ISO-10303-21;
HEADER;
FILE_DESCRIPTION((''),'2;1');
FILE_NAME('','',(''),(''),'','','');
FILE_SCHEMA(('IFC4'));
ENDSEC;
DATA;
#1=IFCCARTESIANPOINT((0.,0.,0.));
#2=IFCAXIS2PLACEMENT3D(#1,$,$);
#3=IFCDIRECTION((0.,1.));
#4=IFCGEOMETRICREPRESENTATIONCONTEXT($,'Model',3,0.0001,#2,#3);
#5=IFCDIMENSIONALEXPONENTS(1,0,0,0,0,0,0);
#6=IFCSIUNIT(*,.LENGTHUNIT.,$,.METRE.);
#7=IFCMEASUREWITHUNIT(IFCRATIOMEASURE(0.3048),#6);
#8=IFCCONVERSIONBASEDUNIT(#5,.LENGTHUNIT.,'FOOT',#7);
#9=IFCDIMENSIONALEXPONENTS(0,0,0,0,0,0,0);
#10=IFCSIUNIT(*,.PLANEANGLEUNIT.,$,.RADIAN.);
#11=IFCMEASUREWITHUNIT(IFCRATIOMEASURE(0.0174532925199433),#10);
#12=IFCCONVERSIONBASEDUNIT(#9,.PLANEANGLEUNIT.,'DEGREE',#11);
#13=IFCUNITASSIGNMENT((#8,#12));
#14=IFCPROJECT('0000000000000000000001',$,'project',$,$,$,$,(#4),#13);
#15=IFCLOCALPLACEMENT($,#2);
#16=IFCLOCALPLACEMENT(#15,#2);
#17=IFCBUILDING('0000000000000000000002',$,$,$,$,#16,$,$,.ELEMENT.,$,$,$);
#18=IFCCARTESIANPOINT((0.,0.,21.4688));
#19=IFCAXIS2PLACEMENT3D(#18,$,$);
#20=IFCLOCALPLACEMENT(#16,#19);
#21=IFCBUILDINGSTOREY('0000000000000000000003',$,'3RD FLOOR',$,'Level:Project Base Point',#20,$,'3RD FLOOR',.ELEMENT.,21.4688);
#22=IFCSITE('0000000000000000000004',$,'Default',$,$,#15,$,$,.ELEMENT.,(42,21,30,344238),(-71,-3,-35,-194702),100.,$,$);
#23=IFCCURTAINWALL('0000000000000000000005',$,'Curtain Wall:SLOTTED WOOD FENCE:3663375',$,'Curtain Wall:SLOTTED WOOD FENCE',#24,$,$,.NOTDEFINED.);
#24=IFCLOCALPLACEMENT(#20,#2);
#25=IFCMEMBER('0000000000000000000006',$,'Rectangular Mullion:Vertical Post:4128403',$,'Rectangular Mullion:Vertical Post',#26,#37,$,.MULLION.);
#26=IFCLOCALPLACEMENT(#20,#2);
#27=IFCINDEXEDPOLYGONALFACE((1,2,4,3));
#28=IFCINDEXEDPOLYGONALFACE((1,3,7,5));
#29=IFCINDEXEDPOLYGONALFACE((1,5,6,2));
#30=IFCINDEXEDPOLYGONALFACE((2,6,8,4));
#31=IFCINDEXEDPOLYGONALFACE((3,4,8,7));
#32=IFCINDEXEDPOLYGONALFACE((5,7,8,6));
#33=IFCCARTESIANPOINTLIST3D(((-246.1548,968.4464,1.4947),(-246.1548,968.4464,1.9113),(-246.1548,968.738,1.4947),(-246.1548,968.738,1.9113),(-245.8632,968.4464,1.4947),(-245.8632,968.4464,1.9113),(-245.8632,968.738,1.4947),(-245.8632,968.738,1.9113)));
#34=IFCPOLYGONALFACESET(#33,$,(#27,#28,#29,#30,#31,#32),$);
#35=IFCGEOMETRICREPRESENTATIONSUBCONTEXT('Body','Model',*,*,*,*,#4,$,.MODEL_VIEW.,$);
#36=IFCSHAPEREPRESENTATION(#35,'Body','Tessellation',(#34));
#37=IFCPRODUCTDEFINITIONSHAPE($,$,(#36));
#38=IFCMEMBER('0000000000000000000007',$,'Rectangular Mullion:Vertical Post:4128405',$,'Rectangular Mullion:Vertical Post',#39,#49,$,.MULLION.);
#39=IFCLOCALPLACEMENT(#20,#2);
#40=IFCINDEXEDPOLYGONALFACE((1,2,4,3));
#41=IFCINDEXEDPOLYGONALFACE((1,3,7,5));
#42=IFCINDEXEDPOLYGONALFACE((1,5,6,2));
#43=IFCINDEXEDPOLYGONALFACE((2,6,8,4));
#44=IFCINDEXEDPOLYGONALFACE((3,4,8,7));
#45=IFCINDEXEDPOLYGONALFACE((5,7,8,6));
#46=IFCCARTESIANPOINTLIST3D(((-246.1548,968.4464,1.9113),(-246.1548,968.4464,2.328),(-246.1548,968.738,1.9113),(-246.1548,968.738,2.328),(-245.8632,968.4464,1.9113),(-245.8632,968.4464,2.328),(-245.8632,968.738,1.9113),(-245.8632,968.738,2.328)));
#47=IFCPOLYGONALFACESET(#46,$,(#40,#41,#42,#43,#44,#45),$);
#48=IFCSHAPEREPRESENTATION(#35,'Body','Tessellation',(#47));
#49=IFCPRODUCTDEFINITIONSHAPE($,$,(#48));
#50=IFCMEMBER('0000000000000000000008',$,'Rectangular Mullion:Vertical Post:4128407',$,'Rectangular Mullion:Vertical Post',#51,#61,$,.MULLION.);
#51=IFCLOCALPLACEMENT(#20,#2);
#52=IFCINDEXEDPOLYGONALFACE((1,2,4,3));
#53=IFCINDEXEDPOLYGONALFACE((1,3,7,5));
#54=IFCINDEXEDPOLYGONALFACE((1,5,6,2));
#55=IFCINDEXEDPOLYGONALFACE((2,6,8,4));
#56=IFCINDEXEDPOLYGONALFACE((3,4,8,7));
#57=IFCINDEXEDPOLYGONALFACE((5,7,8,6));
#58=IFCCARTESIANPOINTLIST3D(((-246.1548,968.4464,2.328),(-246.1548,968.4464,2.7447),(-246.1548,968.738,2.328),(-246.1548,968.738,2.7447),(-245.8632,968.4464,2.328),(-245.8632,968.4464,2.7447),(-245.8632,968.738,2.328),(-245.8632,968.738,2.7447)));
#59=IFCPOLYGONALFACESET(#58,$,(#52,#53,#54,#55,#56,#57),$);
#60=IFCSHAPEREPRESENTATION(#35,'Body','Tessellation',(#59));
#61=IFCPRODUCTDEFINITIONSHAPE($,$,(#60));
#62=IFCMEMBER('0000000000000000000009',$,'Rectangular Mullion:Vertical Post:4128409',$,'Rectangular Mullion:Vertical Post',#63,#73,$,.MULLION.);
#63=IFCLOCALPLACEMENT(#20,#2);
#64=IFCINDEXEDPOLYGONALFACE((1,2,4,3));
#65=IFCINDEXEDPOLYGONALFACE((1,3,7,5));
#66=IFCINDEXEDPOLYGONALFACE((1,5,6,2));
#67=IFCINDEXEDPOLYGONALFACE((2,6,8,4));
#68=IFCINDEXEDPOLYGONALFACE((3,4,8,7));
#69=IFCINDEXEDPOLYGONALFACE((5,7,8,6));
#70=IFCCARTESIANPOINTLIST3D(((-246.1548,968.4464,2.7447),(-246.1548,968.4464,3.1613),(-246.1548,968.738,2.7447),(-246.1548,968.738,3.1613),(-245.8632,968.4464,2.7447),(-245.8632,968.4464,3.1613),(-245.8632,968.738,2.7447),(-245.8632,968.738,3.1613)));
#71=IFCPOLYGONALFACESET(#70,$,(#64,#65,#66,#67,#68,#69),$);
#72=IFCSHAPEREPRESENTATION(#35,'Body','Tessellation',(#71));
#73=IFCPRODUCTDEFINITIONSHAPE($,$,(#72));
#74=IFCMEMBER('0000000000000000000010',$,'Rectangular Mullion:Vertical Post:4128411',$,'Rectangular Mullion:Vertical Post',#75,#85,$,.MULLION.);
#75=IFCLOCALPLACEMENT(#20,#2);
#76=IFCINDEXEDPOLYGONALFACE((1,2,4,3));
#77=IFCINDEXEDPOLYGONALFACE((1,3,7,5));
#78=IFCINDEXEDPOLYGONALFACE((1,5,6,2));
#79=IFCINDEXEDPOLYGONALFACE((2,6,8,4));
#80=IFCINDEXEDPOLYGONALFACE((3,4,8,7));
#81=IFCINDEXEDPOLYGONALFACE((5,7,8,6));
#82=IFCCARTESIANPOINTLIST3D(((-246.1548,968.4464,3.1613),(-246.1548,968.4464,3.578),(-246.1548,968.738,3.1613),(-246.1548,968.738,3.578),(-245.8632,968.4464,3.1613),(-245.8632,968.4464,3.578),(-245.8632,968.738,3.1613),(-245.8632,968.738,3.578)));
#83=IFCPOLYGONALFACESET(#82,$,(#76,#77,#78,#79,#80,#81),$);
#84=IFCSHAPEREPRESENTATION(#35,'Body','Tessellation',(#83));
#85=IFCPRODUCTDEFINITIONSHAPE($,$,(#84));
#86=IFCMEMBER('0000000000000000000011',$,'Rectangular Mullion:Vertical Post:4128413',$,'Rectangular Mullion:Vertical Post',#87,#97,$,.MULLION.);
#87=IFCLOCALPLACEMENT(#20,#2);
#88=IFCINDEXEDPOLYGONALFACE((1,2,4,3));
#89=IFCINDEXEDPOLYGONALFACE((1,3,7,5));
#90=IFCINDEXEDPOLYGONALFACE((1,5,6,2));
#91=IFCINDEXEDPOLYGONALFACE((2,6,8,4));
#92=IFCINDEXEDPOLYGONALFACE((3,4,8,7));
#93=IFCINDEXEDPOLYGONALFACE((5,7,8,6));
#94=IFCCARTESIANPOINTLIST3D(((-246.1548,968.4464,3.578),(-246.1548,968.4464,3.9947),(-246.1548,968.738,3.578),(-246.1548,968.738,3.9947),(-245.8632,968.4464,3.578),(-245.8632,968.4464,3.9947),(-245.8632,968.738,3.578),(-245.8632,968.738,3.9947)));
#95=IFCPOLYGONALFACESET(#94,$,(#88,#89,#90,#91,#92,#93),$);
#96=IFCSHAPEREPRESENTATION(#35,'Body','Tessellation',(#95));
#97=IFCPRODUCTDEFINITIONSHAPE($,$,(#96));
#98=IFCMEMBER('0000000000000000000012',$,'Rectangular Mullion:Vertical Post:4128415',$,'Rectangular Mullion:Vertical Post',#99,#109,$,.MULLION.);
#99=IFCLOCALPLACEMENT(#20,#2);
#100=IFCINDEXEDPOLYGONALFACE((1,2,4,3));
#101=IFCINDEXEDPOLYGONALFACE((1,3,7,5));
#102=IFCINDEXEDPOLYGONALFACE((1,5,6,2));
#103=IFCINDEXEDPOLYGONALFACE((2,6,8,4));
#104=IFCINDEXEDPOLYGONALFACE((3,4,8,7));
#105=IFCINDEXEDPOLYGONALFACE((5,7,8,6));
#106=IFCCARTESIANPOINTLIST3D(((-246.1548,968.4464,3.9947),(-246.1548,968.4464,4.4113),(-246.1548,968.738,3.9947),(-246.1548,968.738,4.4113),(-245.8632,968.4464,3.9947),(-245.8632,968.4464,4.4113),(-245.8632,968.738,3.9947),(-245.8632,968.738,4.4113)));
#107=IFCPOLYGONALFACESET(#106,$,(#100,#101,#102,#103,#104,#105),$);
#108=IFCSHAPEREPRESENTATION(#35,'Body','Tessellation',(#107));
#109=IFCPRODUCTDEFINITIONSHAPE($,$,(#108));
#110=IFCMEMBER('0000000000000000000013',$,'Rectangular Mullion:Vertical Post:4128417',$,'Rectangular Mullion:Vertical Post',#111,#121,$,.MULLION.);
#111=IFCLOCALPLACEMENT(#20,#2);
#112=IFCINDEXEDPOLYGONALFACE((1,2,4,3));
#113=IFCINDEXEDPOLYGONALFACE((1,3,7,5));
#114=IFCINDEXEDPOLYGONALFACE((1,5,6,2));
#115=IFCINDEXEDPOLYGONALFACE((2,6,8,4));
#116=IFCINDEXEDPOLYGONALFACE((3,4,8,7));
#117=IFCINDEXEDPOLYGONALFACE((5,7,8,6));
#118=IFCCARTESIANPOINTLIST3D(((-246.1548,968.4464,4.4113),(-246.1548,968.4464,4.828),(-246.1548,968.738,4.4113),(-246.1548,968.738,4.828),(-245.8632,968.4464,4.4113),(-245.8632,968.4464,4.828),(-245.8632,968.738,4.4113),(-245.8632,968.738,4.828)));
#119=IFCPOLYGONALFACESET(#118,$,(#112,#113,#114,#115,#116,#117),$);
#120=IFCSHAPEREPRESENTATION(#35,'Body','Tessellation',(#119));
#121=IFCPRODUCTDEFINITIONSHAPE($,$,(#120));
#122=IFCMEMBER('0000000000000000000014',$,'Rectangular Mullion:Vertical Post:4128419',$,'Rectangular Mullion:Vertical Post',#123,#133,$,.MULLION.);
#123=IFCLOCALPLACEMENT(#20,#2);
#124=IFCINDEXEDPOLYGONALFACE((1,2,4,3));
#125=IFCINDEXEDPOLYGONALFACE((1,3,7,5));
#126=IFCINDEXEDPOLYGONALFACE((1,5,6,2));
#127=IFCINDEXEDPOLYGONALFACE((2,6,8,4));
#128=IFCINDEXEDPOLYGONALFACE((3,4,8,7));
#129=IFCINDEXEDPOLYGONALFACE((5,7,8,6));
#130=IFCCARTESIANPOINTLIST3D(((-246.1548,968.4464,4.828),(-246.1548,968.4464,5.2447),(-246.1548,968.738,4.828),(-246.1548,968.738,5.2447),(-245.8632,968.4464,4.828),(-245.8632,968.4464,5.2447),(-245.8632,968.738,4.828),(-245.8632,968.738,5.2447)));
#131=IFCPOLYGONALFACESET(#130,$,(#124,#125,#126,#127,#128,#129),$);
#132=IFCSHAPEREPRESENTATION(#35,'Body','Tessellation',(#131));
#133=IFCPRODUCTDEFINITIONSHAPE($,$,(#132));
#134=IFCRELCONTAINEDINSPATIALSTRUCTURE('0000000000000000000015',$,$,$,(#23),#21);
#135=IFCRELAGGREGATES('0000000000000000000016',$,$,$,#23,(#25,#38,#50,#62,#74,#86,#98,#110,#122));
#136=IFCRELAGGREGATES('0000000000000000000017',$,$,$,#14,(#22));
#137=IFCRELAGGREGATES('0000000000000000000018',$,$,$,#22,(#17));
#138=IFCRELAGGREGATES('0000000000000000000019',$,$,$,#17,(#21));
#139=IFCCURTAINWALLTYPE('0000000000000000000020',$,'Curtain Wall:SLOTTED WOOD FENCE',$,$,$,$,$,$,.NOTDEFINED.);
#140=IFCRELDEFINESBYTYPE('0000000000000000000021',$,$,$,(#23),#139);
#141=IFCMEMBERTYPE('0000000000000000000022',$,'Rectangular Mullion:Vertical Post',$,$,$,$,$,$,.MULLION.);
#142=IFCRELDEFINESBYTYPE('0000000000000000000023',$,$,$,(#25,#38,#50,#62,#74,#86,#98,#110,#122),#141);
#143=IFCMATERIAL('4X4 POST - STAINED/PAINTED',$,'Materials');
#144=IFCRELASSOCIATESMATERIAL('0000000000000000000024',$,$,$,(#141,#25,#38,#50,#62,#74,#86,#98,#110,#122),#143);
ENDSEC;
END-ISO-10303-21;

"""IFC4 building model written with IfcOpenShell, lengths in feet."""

from ifc_helpers import new_model, entity, si_unit, converted_unit, direction, frame, origin, origin_2d_with_axis, place, context, subcontext, project, spatial, rectangle, extrude, source, transform, mapped, material, material_profile, profile_set, profile_usage, type_object, type_shapes, element, aggregate, save


model = new_model("IFC4")

# Units and contexts
model_context = context("Model", 3, precision=0.0001, world=origin(), true_north=direction((0.0, 1.0)))
body_context = subcontext(model_context, "Body", "Model", "MODEL_VIEW")
ifc_project = project(units=[converted_unit("LENGTHUNIT", "FOOT", entity("IfcRatioMeasure", 0.3048), si_unit("LENGTHUNIT", "METRE"), dimensions=[1, 0, 0, 0, 0, 0, 0]), converted_unit("PLANEANGLEUNIT", "DEGREE", entity("IfcRatioMeasure", 0.0174532925199433), si_unit("PLANEANGLEUNIT", "RADIAN"), dimensions=[0, 0, 0, 0, 0, 0, 0])], contexts=[model_context])

# Site, building, storey
site_placement = place(None, origin())
site = spatial("IfcSite", under=ifc_project, at=site_placement, Name="Default", CompositionType="ELEMENT", RefLatitude=(42, 21, 30, 344238), RefLongitude=(-71, -3, -35, -194702), RefElevation=100.0)
building_placement = place(site_placement, origin())
building = spatial("IfcBuilding", under=site, at=building_placement, CompositionType="ELEMENT")
storey_placement = place(building_placement, frame((0.0, 0.0, 21.4688)))
storey = spatial("IfcBuildingStorey", under=building, at=storey_placement, Name="3RD FLOOR", ObjectType="Level:Project Base Point", LongName="3RD FLOOR", CompositionType="ELEMENT", Elevation=21.4688)

# Curtain wall, members
curtain_wall_type = type_object("IfcCurtainWallType", Name="Curtain Wall:SLOTTED WOOD FENCE", PredefinedType="NOTDEFINED")
curtain_wall_placement = place(storey_placement, frame((0.0, 0.0, -21.4688)))
curtain_wall = element("IfcCurtainWall", 1, at=curtain_wall_placement, inside=storey, type_object=curtain_wall_type, Name="Curtain Wall:SLOTTED WOOD FENCE:3663375", ObjectType="Curtain Wall:SLOTTED WOOD FENCE", PredefinedType="NOTDEFINED")
ifc_material = material(Name="4X4 POST - STAINED/PAINTED", Category="Materials")
ifc_material_profile = material_profile(ifc_material, rectangle(XDim=0.2917, YDim=0.2917, at=origin_2d_with_axis()), Name="Vertical Post")
ifc_profile_set = profile_set([ifc_material_profile], Name="Vertical Post")
member_type_1 = type_object("IfcMemberType", Name="Rectangular Mullion:Vertical Post", PredefinedType="MULLION", material=ifc_profile_set)
shared_shape_1 = source(origin(), body_context, "Body", "SweptSolid", [
    extrude(rectangle(XDim=0.2917, YDim=0.2917, at=origin_2d_with_axis()), frame((0.0, 0.2083, -0.4167), z_axis=(0.0, 0.0, 1.0), x_axis=(0.0, -1.0, 0.0)), (0.0, 0.0, 1.0), 0.4167),
])
type_shapes(member_type_1, [shared_shape_1])
ifc_profile_usage_1 = profile_usage(ifc_profile_set)
member_1_placement = place(storey_placement, frame((-245.8007, 968.5922, 1.4947), z_axis=(0.0, 0.0, -1.0), x_axis=(0.0, -1.0, 0.0)))
member_1 = element("IfcMember", 2, at=member_1_placement, type_object=member_type_1, material=ifc_profile_usage_1, Name="Rectangular Mullion:Vertical Post:4128403", ObjectType="Rectangular Mullion:Vertical Post", PredefinedType="MULLION", context=body_context, shape_type="MappedRepresentation", body=[
    mapped(shared_shape_1, transform((0.0, 0.0, 0.0), scale=1.0)),
])
ifc_profile_usage_2 = profile_usage(ifc_profile_set)
member_2_placement = place(storey_placement, frame((-245.8007, 968.5922, 1.9113), z_axis=(0.0, 0.0, -1.0), x_axis=(0.0, -1.0, 0.0)))
member_2 = element("IfcMember", 3, at=member_2_placement, type_object=member_type_1, material=ifc_profile_usage_2, Name="Rectangular Mullion:Vertical Post:4128405", ObjectType="Rectangular Mullion:Vertical Post", PredefinedType="MULLION", context=body_context, shape_type="MappedRepresentation", body=[
    mapped(shared_shape_1, transform((0.0, 0.0, 0.0), scale=1.0)),
])
ifc_profile_usage_3 = profile_usage(ifc_profile_set)
member_3_placement = place(storey_placement, frame((-245.8007, 968.5922, 2.328), z_axis=(0.0, 0.0, -1.0), x_axis=(0.0, -1.0, 0.0)))
member_3 = element("IfcMember", 4, at=member_3_placement, type_object=member_type_1, material=ifc_profile_usage_3, Name="Rectangular Mullion:Vertical Post:4128407", ObjectType="Rectangular Mullion:Vertical Post", PredefinedType="MULLION", context=body_context, shape_type="MappedRepresentation", body=[
    mapped(shared_shape_1, transform((0.0, 0.0, 0.0), scale=1.0)),
])
ifc_profile_usage_4 = profile_usage(ifc_profile_set)
member_4_placement = place(storey_placement, frame((-245.8007, 968.5922, 2.7447), z_axis=(0.0, 0.0, -1.0), x_axis=(0.0, -1.0, 0.0)))
member_4 = element("IfcMember", 5, at=member_4_placement, type_object=member_type_1, material=ifc_profile_usage_4, Name="Rectangular Mullion:Vertical Post:4128409", ObjectType="Rectangular Mullion:Vertical Post", PredefinedType="MULLION", context=body_context, shape_type="MappedRepresentation", body=[
    mapped(shared_shape_1, transform((0.0, 0.0, 0.0), scale=1.0)),
])
ifc_profile_usage_5 = profile_usage(ifc_profile_set)
member_5_placement = place(storey_placement, frame((-245.8007, 968.5922, 3.1613), z_axis=(0.0, 0.0, -1.0), x_axis=(0.0, -1.0, 0.0)))
member_5 = element("IfcMember", 6, at=member_5_placement, type_object=member_type_1, material=ifc_profile_usage_5, Name="Rectangular Mullion:Vertical Post:4128411", ObjectType="Rectangular Mullion:Vertical Post", PredefinedType="MULLION", context=body_context, shape_type="MappedRepresentation", body=[
    mapped(shared_shape_1, transform((0.0, 0.0, 0.0), scale=1.0)),
])
ifc_profile_usage_6 = profile_usage(ifc_profile_set)
member_6_placement = place(storey_placement, frame((-245.8007, 968.5922, 3.578), z_axis=(0.0, 0.0, -1.0), x_axis=(0.0, -1.0, 0.0)))
member_6 = element("IfcMember", 7, at=member_6_placement, type_object=member_type_1, material=ifc_profile_usage_6, Name="Rectangular Mullion:Vertical Post:4128413", ObjectType="Rectangular Mullion:Vertical Post", PredefinedType="MULLION", context=body_context, shape_type="MappedRepresentation", body=[
    mapped(shared_shape_1, transform((0.0, 0.0, 0.0), scale=1.0)),
])
ifc_profile_usage_7 = profile_usage(ifc_profile_set)
member_7_placement = place(storey_placement, frame((-245.8007, 968.5922, 3.9947), z_axis=(0.0, 0.0, -1.0), x_axis=(0.0, -1.0, 0.0)))
member_7 = element("IfcMember", 8, at=member_7_placement, type_object=member_type_1, material=ifc_profile_usage_7, Name="Rectangular Mullion:Vertical Post:4128415", ObjectType="Rectangular Mullion:Vertical Post", PredefinedType="MULLION", context=body_context, shape_type="MappedRepresentation", body=[
    mapped(shared_shape_1, transform((0.0, 0.0, 0.0), scale=1.0)),
])
ifc_profile_usage_8 = profile_usage(ifc_profile_set)
member_8_placement = place(storey_placement, frame((-245.8007, 968.5922, 4.4113), z_axis=(0.0, 0.0, -1.0), x_axis=(0.0, -1.0, 0.0)))
member_8 = element("IfcMember", 9, at=member_8_placement, type_object=member_type_1, material=ifc_profile_usage_8, Name="Rectangular Mullion:Vertical Post:4128417", ObjectType="Rectangular Mullion:Vertical Post", PredefinedType="MULLION", context=body_context, shape_type="MappedRepresentation", body=[
    mapped(shared_shape_1, transform((0.0, 0.0, 0.0), scale=1.0)),
])
ifc_profile_usage_9 = profile_usage(ifc_profile_set)
member_9_placement = place(storey_placement, frame((-245.8007, 968.5922, 4.828), z_axis=(0.0, 0.0, -1.0), x_axis=(0.0, -1.0, 0.0)))
member_9 = element("IfcMember", 10, at=member_9_placement, type_object=member_type_1, material=ifc_profile_usage_9, Name="Rectangular Mullion:Vertical Post:4128419", ObjectType="Rectangular Mullion:Vertical Post", PredefinedType="MULLION", context=body_context, shape_type="MappedRepresentation", body=[
    mapped(shared_shape_1, transform((0.0, 0.0, 0.0), scale=1.0)),
])
aggregate(curtain_wall, [member_1, member_2, member_3, member_4, member_5, member_6, member_7, member_8, member_9])

save(model, "model.ifc")
